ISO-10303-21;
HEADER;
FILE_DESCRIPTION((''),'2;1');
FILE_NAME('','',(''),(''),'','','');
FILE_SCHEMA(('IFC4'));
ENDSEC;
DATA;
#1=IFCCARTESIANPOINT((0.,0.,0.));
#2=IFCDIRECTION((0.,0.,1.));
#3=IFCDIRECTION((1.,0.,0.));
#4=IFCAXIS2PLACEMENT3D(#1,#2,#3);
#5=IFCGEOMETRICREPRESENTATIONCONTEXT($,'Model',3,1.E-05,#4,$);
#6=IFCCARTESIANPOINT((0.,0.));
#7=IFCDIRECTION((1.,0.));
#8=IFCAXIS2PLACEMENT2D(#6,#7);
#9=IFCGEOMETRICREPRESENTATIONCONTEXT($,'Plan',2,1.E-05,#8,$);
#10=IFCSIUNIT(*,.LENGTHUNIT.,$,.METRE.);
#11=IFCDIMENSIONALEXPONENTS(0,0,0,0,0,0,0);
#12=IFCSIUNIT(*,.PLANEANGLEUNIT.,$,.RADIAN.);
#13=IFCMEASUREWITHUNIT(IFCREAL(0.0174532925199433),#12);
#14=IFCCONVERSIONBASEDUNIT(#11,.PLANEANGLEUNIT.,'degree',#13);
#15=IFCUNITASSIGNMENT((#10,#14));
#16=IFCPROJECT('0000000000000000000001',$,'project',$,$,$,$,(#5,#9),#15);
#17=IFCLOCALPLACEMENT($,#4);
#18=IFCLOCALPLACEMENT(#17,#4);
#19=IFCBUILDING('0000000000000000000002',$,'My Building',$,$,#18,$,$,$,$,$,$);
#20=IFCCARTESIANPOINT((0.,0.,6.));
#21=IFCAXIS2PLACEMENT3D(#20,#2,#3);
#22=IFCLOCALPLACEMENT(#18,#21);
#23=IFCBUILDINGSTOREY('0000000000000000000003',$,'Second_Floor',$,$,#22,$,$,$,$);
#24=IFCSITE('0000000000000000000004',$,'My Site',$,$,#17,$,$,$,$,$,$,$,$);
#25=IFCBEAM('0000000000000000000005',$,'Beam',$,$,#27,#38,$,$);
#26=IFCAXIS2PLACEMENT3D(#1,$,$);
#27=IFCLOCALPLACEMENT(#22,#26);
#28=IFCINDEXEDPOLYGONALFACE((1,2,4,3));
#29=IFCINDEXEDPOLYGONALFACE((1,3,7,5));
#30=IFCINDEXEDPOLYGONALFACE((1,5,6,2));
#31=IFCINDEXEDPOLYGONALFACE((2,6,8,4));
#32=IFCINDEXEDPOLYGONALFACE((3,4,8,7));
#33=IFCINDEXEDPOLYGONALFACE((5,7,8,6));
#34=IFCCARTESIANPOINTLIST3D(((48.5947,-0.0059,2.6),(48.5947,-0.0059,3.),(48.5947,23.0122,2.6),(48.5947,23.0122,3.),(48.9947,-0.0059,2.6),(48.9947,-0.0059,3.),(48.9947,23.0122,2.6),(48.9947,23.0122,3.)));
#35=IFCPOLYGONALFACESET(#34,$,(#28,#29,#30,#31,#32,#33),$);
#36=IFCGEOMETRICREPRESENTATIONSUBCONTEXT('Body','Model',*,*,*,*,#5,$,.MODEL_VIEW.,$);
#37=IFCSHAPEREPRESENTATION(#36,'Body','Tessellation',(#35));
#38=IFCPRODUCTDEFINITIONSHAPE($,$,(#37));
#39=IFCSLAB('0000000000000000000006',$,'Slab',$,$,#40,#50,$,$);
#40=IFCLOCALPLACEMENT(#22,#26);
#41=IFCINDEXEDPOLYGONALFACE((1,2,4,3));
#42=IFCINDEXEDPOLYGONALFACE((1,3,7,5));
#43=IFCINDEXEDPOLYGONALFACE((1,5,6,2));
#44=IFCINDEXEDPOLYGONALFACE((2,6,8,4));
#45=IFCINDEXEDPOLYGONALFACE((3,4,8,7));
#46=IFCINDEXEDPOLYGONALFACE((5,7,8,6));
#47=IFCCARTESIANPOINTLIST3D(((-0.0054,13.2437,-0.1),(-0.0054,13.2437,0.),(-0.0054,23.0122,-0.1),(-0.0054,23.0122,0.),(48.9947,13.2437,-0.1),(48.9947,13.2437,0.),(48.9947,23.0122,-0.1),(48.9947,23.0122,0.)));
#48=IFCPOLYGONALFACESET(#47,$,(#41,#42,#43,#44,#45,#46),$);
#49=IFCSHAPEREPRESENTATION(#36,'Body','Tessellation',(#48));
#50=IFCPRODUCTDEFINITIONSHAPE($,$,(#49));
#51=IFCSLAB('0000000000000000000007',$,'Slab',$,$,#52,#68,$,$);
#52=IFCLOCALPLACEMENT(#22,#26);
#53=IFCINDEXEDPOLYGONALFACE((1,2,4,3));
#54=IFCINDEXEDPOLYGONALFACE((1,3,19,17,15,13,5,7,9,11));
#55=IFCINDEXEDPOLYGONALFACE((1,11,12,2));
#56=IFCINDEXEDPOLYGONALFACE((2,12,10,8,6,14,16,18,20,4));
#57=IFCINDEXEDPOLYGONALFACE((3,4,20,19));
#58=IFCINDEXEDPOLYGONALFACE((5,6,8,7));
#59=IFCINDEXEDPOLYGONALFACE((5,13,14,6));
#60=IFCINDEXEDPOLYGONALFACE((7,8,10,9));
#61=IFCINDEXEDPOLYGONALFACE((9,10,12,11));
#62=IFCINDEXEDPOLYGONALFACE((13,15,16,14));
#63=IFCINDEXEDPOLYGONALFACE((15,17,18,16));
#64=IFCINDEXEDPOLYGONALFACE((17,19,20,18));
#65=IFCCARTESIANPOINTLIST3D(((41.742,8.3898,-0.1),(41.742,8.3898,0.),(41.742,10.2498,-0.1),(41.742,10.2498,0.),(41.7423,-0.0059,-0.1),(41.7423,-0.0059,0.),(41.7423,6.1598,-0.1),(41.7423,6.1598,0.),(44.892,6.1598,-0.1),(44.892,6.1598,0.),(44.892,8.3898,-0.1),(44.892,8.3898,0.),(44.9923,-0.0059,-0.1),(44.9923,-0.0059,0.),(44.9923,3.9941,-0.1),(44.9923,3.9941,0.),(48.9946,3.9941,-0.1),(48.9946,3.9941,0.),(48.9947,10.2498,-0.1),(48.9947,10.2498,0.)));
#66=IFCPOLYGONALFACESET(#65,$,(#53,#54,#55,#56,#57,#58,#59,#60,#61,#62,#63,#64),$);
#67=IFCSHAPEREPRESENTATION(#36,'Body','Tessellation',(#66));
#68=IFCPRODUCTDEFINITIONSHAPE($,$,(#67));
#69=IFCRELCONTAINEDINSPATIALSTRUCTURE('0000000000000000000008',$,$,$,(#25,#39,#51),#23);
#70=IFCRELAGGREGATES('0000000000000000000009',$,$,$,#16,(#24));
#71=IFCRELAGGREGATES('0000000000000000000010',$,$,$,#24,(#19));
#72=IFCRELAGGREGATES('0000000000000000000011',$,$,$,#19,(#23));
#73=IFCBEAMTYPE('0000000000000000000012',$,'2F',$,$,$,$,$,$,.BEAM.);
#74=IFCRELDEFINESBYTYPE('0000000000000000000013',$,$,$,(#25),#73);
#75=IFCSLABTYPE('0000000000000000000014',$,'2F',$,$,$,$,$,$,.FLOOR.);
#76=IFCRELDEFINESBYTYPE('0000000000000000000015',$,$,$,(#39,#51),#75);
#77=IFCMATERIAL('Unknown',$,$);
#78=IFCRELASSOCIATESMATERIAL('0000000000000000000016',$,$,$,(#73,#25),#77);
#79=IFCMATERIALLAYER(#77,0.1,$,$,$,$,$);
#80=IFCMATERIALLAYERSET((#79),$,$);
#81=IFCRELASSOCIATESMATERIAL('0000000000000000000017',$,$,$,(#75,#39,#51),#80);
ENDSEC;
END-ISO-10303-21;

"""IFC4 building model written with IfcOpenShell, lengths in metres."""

from ifc_helpers import new_model, entity, si_unit, converted_unit, frame, origin_with_axes, origin_2d_with_axis, place, context, subcontext, project, spatial, indexed_curve, rectangle, outline, extrude, material, layer, layer_set, layer_usage, material_profile, profile_set, profile_usage, type_object, element, save


model = new_model("IFC4")

# Units and contexts
model_context = context("Model", 3, precision=1e-05, world=origin_with_axes())
plan_context = context("Plan", 2, precision=1e-05, world=origin_2d_with_axis())
body_context = subcontext(model_context, "Body", "Model", "MODEL_VIEW")
ifc_project = project(units=[si_unit("LENGTHUNIT", "METRE"), converted_unit("PLANEANGLEUNIT", "degree", entity("IfcReal", 0.0174532925199433), si_unit("PLANEANGLEUNIT", "RADIAN"), dimensions=[0, 0, 0, 0, 0, 0, 0])], contexts=[model_context, plan_context])

# Site, building, storey
site_placement = place(None, origin_with_axes())
site = spatial("IfcSite", under=ifc_project, at=site_placement, Name="My Site")
building_placement = place(site_placement, origin_with_axes())
building = spatial("IfcBuilding", under=site, at=building_placement, Name="My Building")
storey_placement = place(building_placement, frame((0.0, 0.0, 6.0), z_axis=(0.0, 0.0, 1.0), x_axis=(1.0, 0.0, 0.0)))
storey = spatial("IfcBuildingStorey", under=building, at=storey_placement, Name="Second_Floor")

# Shared definitions
ifc_material = material(Name="Unknown")

# Beam
ifc_material_profile_1 = material_profile(ifc_material, rectangle(XDim=0.4, YDim=0.4))
ifc_profile_set_1 = profile_set([ifc_material_profile_1])
beam_type = type_object("IfcBeamType", Name="2F", PredefinedType="BEAM", material=ifc_profile_set_1)
ifc_profile_usage_1 = profile_usage(ifc_profile_set_1, cardinal=8)
beam_1_placement = place(storey_placement, frame((48.7947, -0.0059, 3.0), z_axis=(0.0, 1.0, 0.0), x_axis=(-1.0, 0.0, 0.0)))
element("IfcBeam", 1, at=beam_1_placement, inside=storey, type_object=beam_type, material=ifc_profile_usage_1, Name="Beam", context=body_context, shape_type="SweptSolid", body=[
    extrude(rectangle(XDim=0.4, YDim=0.4), frame((0.0, -0.2, 0.0), z_axis=(0.0, 0.0, 1.0), x_axis=(1.0, 0.0, 0.0)), (0.0, 0.0, 1.0), 23.0181),
])

# Slabs
ifc_layer = layer(ifc_material, 0.1)
ifc_layer_set = layer_set([ifc_layer])
ifc_layer_usage_1 = layer_usage(ifc_layer_set, "AXIS3", "POSITIVE", -0.1)
slab_type = type_object("IfcSlabType", Name="2F", PredefinedType="FLOOR", material=ifc_layer_set)
slab_1_placement = place(storey_placement, frame((48.9947, 23.0122, 0.0), z_axis=(0.0, 0.0, 1.0), x_axis=(1.0, 0.0, 0.0)))
element("IfcSlab", 2, at=slab_1_placement, inside=storey, type_object=slab_type, material=ifc_layer_usage_1, Name="Slab", context=body_context, shape_type="SweptSolid", body=[
    extrude(outline(indexed_curve([(0.0, 0.0), (0.0, -9.7685), (-49.0001, -9.7685), (-49.0001, 0.0), (0.0, 0.0)])), frame((0.0, 0.0, -0.1), z_axis=(0.0, 0.0, 1.0), x_axis=(1.0, 0.0, 0.0)), (0.0, 0.0, 1.0), 0.1),
])
ifc_layer_usage_2 = layer_usage(ifc_layer_set, "AXIS3", "POSITIVE", -0.1)
slab_2_placement = place(storey_placement, frame((48.9947, 10.2498, 0.0), z_axis=(0.0, 0.0, 1.0), x_axis=(1.0, 0.0, 0.0)))
element("IfcSlab", 3, at=slab_2_placement, inside=storey, type_object=slab_type, material=ifc_layer_usage_2, Name="Slab", context=body_context, shape_type="SweptSolid", body=[
    extrude(outline(indexed_curve([(0.0, 0.0), (-7.2527, 0.0), (-7.2527, -1.86), (-4.1027, -1.86), (-4.1027, -4.09), (-7.2524, -4.09), (-7.2524, -10.2557), (-4.0024, -10.2557), (-4.0024, -6.2557), (-0.0001, -6.2557), (0.0, 0.0)])), frame((0.0, 0.0, -0.1), z_axis=(0.0, 0.0, 1.0), x_axis=(1.0, 0.0, 0.0)), (0.0, 0.0, 1.0), 0.1),
])

save(model, "model.ifc")
